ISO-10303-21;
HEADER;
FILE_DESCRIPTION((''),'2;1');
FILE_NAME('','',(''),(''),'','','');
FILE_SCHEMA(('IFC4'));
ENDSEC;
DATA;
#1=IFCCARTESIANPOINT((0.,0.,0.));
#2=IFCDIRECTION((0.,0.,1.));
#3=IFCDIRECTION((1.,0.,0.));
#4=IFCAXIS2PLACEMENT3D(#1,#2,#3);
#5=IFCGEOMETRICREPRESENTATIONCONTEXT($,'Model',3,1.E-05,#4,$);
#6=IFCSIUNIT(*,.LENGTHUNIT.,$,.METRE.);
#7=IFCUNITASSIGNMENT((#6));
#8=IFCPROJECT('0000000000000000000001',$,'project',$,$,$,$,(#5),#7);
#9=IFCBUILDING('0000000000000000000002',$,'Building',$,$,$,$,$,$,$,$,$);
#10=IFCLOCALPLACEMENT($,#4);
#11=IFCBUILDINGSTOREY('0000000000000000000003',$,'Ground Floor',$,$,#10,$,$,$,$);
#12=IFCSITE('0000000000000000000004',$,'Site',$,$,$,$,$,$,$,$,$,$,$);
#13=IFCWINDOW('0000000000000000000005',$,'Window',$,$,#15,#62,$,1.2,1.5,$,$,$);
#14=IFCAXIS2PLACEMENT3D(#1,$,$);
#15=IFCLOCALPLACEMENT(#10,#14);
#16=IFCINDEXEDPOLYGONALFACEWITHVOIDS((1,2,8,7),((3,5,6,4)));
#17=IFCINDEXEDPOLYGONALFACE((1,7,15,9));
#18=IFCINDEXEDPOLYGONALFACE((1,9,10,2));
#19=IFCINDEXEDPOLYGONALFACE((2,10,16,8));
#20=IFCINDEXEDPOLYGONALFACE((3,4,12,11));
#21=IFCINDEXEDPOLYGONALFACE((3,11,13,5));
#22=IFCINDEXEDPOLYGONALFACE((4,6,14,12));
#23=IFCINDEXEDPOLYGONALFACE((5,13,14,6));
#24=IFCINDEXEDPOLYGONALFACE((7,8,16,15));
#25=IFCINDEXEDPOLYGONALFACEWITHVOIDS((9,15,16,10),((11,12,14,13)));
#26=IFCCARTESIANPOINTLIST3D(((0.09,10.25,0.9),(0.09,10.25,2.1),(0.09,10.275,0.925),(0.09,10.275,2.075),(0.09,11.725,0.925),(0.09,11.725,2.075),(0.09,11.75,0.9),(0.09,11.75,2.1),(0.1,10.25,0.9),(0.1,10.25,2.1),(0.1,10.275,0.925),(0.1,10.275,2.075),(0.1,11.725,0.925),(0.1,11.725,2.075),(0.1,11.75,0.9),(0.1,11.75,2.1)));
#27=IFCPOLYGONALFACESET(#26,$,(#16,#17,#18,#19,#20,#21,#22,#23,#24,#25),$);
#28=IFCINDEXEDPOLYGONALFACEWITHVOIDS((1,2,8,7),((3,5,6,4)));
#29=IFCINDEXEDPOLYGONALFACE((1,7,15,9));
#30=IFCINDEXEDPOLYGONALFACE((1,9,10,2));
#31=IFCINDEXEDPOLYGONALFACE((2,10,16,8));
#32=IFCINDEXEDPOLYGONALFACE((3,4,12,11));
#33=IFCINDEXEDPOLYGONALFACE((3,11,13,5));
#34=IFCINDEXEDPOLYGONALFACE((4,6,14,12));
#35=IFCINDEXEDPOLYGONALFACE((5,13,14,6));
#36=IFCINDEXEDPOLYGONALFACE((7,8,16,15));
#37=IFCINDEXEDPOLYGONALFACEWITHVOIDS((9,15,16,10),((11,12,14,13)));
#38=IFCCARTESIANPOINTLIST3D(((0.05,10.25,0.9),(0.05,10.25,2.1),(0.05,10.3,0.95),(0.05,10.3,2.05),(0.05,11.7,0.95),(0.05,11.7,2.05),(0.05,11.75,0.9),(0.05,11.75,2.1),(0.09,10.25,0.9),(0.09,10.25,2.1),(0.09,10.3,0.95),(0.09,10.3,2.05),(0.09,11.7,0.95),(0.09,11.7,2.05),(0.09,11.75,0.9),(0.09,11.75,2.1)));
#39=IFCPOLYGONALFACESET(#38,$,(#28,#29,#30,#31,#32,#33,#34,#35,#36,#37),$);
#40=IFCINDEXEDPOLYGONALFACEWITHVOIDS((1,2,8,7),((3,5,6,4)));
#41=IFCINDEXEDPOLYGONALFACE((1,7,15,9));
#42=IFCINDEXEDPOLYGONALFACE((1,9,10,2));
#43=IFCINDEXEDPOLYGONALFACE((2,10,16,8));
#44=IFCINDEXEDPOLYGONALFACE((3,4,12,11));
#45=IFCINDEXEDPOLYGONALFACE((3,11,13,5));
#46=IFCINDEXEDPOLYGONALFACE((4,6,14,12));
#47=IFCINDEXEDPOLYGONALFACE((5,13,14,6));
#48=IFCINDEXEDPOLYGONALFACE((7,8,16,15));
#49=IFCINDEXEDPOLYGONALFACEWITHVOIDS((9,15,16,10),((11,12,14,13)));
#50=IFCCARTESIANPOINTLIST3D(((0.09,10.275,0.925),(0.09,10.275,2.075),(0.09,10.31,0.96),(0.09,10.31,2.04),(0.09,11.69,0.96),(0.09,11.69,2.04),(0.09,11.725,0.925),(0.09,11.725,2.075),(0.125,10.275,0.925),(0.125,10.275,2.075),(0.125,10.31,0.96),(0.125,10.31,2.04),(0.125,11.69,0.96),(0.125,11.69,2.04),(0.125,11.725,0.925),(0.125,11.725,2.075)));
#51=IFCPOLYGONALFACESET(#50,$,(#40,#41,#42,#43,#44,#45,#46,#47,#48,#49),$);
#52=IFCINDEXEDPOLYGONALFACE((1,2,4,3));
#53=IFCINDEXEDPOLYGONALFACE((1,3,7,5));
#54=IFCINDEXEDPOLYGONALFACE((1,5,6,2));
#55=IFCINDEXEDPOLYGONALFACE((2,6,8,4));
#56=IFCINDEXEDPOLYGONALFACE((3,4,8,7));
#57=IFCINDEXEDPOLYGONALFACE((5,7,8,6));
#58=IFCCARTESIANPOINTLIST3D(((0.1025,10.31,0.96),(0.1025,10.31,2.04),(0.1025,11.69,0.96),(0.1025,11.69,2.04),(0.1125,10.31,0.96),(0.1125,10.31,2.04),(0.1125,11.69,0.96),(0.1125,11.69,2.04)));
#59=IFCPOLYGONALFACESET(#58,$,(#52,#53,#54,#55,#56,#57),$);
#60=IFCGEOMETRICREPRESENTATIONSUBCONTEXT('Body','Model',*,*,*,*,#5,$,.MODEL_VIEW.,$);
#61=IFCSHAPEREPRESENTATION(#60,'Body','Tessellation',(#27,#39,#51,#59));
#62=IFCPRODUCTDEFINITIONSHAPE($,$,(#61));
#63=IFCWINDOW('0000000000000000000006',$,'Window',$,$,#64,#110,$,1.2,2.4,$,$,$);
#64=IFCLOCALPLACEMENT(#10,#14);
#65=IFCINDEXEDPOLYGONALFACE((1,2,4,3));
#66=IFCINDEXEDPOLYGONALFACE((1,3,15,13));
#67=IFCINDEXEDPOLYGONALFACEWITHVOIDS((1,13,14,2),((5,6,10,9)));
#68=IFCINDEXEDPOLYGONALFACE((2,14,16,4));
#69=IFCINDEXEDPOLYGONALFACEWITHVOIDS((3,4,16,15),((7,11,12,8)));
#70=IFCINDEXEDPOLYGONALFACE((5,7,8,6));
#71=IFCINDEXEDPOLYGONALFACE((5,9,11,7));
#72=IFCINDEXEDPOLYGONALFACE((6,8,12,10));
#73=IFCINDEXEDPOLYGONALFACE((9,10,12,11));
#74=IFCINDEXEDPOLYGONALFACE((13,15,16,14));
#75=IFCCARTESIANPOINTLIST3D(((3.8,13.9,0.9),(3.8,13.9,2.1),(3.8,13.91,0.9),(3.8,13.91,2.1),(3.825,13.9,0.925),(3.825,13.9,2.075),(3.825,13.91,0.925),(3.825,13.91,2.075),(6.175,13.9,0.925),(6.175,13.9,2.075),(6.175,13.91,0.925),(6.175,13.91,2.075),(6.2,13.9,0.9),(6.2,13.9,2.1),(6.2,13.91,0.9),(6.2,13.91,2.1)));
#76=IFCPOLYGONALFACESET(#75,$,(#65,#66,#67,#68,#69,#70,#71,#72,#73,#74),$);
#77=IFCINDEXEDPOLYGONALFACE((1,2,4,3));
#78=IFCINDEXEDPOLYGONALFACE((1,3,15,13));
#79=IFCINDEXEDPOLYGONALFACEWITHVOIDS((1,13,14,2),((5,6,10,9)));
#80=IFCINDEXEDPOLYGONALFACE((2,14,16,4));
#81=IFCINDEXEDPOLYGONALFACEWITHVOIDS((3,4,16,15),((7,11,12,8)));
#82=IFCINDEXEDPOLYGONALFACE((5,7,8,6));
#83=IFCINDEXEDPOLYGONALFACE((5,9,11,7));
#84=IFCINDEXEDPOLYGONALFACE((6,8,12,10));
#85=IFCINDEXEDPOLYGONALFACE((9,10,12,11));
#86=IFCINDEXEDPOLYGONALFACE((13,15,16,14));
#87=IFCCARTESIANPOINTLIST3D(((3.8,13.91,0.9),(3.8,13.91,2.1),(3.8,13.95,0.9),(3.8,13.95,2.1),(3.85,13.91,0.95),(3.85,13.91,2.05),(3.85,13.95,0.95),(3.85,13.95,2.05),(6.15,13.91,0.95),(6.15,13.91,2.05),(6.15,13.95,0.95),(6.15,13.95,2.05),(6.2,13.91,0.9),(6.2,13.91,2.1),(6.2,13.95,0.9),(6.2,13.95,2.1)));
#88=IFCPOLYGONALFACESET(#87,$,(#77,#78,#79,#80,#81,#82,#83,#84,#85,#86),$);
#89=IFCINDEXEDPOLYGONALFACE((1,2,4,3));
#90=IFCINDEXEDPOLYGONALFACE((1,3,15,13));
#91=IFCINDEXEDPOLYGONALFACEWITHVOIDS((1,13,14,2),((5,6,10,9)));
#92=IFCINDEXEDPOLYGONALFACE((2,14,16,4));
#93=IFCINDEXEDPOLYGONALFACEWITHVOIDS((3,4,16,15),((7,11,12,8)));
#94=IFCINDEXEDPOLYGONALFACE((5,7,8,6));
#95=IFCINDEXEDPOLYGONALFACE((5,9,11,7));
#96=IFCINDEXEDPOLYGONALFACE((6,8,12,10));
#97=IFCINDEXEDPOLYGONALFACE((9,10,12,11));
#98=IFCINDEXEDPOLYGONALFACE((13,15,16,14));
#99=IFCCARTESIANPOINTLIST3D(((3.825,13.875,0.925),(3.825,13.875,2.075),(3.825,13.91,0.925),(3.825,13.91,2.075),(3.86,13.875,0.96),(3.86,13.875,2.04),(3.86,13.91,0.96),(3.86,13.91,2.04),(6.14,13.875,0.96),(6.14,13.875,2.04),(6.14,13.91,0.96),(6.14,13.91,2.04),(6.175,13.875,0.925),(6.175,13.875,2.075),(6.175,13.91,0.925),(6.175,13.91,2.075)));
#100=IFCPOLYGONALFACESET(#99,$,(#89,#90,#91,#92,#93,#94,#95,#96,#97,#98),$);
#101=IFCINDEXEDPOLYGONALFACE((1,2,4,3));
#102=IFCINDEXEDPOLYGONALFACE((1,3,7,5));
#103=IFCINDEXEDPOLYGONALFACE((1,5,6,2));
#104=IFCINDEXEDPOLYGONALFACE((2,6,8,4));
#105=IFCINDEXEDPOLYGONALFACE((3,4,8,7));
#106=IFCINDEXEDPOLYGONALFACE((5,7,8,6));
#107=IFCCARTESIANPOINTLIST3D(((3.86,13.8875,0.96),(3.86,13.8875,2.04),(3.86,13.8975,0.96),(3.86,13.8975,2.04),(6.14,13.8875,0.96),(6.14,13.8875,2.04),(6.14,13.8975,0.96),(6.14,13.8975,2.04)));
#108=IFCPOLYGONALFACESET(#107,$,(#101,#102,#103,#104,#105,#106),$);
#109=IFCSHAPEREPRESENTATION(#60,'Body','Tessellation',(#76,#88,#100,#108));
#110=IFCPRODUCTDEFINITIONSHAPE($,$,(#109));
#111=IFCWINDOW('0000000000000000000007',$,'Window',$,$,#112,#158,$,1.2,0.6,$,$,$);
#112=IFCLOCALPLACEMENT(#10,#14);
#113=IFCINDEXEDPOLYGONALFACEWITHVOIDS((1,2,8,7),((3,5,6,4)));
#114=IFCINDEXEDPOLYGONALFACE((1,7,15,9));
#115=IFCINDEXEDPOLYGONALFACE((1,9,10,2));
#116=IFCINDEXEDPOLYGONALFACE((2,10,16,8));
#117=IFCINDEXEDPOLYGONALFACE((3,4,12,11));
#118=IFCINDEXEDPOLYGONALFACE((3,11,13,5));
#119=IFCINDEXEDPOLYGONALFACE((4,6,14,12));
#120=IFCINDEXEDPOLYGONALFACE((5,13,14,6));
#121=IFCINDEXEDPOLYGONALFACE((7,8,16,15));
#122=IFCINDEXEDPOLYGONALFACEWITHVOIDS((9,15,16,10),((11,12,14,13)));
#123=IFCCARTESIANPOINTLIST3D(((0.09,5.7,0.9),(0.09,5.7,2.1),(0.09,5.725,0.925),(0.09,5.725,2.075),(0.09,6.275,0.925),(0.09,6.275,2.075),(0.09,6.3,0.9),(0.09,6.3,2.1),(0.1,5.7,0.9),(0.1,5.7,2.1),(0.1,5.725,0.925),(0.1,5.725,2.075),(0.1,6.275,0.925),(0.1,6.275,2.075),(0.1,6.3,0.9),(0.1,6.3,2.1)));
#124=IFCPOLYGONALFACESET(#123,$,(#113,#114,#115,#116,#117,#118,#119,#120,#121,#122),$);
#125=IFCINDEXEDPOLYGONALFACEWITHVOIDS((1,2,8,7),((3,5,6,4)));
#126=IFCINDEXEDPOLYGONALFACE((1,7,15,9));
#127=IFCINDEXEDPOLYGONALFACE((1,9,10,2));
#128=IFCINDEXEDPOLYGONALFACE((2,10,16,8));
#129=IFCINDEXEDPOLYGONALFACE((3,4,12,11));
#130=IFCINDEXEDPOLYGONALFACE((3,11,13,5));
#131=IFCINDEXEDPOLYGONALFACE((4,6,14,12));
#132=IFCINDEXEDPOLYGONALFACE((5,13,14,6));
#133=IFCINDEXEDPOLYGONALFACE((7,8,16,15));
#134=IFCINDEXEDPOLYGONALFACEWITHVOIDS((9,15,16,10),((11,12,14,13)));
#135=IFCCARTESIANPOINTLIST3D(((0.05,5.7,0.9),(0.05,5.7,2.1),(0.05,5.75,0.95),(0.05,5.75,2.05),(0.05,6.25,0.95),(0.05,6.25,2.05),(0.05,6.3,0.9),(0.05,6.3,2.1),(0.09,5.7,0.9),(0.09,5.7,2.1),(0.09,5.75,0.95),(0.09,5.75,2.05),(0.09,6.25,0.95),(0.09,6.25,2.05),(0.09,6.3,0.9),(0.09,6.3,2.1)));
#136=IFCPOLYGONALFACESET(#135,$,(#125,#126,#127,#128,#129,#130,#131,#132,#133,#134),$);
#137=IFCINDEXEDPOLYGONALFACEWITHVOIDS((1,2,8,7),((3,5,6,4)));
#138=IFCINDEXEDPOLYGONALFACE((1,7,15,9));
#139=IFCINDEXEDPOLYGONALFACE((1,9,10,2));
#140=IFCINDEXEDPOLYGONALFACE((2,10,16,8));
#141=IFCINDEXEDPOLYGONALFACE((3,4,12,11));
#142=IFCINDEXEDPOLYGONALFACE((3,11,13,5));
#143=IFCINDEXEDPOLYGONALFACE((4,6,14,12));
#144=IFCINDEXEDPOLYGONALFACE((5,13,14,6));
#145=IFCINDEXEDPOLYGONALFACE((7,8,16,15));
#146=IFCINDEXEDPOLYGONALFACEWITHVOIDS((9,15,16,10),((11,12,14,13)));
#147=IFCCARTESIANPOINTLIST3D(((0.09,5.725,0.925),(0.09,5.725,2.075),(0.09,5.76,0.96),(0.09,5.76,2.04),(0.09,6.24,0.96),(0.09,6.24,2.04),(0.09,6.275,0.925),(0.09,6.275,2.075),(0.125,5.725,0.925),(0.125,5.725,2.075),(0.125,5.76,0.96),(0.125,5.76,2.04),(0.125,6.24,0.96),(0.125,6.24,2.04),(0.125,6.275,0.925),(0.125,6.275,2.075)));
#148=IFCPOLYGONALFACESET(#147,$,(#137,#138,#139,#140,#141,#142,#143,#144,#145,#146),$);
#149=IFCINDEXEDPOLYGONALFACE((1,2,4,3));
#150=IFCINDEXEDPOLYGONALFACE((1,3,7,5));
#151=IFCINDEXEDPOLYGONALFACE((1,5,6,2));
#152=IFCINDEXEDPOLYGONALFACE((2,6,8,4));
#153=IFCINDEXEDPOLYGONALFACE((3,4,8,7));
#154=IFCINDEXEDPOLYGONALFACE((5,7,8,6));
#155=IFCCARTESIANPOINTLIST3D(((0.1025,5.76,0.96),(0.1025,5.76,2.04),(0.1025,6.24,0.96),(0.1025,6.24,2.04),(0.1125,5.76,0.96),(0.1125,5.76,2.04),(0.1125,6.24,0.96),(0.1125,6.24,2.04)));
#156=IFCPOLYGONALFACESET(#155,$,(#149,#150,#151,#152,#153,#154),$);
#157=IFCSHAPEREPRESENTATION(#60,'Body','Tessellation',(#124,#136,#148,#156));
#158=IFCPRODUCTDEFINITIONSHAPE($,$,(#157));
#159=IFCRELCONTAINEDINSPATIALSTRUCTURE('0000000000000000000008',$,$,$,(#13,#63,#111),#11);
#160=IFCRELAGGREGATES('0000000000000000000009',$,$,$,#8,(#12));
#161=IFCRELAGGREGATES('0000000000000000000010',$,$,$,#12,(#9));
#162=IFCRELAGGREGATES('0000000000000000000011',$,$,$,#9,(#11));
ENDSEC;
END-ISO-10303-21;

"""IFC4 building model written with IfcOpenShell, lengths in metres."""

from ifc_helpers import new_model, si_unit, frame, origin_with_axes, place, context, subcontext, project, spatial, line, indexed_curve, outline, extrude, element, save


model = new_model("IFC4")

# Units and contexts
model_context = context("Model", 3, precision=1e-05, world=origin_with_axes())
body_context = subcontext(model_context, "Body", "Model", "MODEL_VIEW")
ifc_project = project(units=[si_unit("LENGTHUNIT", "METRE")], contexts=[model_context])

# Site, building, storey
site = spatial("IfcSite", under=ifc_project, Name="Site")
building = spatial("IfcBuilding", under=site, Name="Building")
storey_placement = place(None, origin_with_axes())
storey = spatial("IfcBuildingStorey", under=building, at=storey_placement, Name="Ground Floor")

# Windows
for number, where, z_axis, x_axis, name in (
    (1, (0.0, 11.75, 0.9), (0.0, 0.0, 1.0), (0.0, -1.0, 0.0), "Window"),
):
    element("IfcWindow", number, at=place(storey_placement, frame(where, z_axis=z_axis, x_axis=x_axis)), inside=storey, Name=name, OverallHeight=1.2, OverallWidth=1.5, context=body_context, shape_type="SweptSolid", body=[
        extrude(outline(indexed_curve([(0.0, 0.0), (1.5, 0.0), (1.5, 1.2), (0.0, 1.2)], segments=[line(1, 2, 3, 4, 1)]), holes=[indexed_curve([(0.025, 0.025), (1.475, 0.025), (1.475, 1.175), (0.025, 1.175)], segments=[line(1, 2, 3, 4, 1)])]), frame((0.0, 0.09, 0.0), z_axis=(0.0, -1.0, 0.0), x_axis=(1.0, 0.0, 0.0)), (0.0, 0.0, -1.0), 0.01),
        extrude(outline(indexed_curve([(0.0, 0.0), (1.5, 0.0), (1.5, 1.2), (0.0, 1.2)], segments=[line(1, 2, 3, 4, 1)]), holes=[indexed_curve([(0.05, 0.05), (1.45, 0.05), (1.45, 1.15), (0.05, 1.15)], segments=[line(1, 2, 3, 4, 1)])]), frame((0.0, 0.05, 0.0), z_axis=(0.0, -1.0, 0.0), x_axis=(1.0, 0.0, 0.0)), (0.0, 0.0, -1.0), 0.04),
        extrude(outline(indexed_curve([(0.0, 0.0), (1.45, 0.0), (1.45, 1.15), (0.0, 1.15)], segments=[line(1, 2, 3, 4, 1)]), holes=[indexed_curve([(0.035, 0.035), (1.415, 0.035), (1.415, 1.115), (0.035, 1.115)], segments=[line(1, 2, 3, 4, 1)])]), frame((0.025, 0.09, 0.025), z_axis=(0.0, -1.0, 0.0), x_axis=(1.0, 0.0, 0.0)), (0.0, 0.0, -1.0), 0.035),
        extrude(outline(indexed_curve([(0.035, 0.035), (1.415, 0.035), (1.415, 1.115), (0.035, 1.115)], segments=[line(1, 2, 3, 4, 1)])), frame((0.025, 0.1025, 0.025), z_axis=(0.0, -1.0, 0.0), x_axis=(1.0, 0.0, 0.0)), (0.0, 0.0, -1.0), 0.01),
    ])
window_1_placement = place(storey_placement, frame((6.2, 14.0, 0.9), z_axis=(0.0, 0.0, 1.0), x_axis=(-1.0, 0.0, 0.0)))
element("IfcWindow", 2, at=window_1_placement, inside=storey, Name="Window", OverallHeight=1.2, OverallWidth=2.4, context=body_context, shape_type="SweptSolid", body=[
    extrude(outline(indexed_curve([(0.0, 0.0), (2.4, 0.0), (2.4, 1.2), (0.0, 1.2)], segments=[line(1, 2, 3, 4, 1)]), holes=[indexed_curve([(0.025, 0.025), (2.375, 0.025), (2.375, 1.175), (0.025, 1.175)], segments=[line(1, 2, 3, 4, 1)])]), frame((0.0, 0.09, 0.0), z_axis=(0.0, -1.0, 0.0), x_axis=(1.0, 0.0, 0.0)), (0.0, 0.0, -1.0), 0.01),
    extrude(outline(indexed_curve([(0.0, 0.0), (2.4, 0.0), (2.4, 1.2), (0.0, 1.2)], segments=[line(1, 2, 3, 4, 1)]), holes=[indexed_curve([(0.05, 0.05), (2.35, 0.05), (2.35, 1.15), (0.05, 1.15)], segments=[line(1, 2, 3, 4, 1)])]), frame((0.0, 0.05, 0.0), z_axis=(0.0, -1.0, 0.0), x_axis=(1.0, 0.0, 0.0)), (0.0, 0.0, -1.0), 0.04),
    extrude(outline(indexed_curve([(0.0, 0.0), (2.35, 0.0), (2.35, 1.15), (0.0, 1.15)], segments=[line(1, 2, 3, 4, 1)]), holes=[indexed_curve([(0.035, 0.035), (2.315, 0.035), (2.315, 1.115), (0.035, 1.115)], segments=[line(1, 2, 3, 4, 1)])]), frame((0.025, 0.09, 0.025), z_axis=(0.0, -1.0, 0.0), x_axis=(1.0, 0.0, 0.0)), (0.0, 0.0, -1.0), 0.035),
    extrude(outline(indexed_curve([(0.035, 0.035), (2.315, 0.035), (2.315, 1.115), (0.035, 1.115)], segments=[line(1, 2, 3, 4, 1)])), frame((0.025, 0.1025, 0.025), z_axis=(0.0, -1.0, 0.0), x_axis=(1.0, 0.0, 0.0)), (0.0, 0.0, -1.0), 0.01),
])
window_2_placement = place(storey_placement, frame((0.0, 6.3, 0.9), z_axis=(0.0, 0.0, 1.0), x_axis=(0.0, -1.0, 0.0)))
element("IfcWindow", 3, at=window_2_placement, inside=storey, Name="Window", OverallHeight=1.2, OverallWidth=0.6, context=body_context, shape_type="SweptSolid", body=[
    extrude(outline(indexed_curve([(0.0, 0.0), (0.6, 0.0), (0.6, 1.2), (0.0, 1.2)], segments=[line(1, 2, 3, 4, 1)]), holes=[indexed_curve([(0.025, 0.025), (0.575, 0.025), (0.575, 1.175), (0.025, 1.175)], segments=[line(1, 2, 3, 4, 1)])]), frame((0.0, 0.09, 0.0), z_axis=(0.0, -1.0, 0.0), x_axis=(1.0, 0.0, 0.0)), (0.0, 0.0, -1.0), 0.01),
    extrude(outline(indexed_curve([(0.0, 0.0), (0.6, 0.0), (0.6, 1.2), (0.0, 1.2)], segments=[line(1, 2, 3, 4, 1)]), holes=[indexed_curve([(0.05, 0.05), (0.55, 0.05), (0.55, 1.15), (0.05, 1.15)], segments=[line(1, 2, 3, 4, 1)])]), frame((0.0, 0.05, 0.0), z_axis=(0.0, -1.0, 0.0), x_axis=(1.0, 0.0, 0.0)), (0.0, 0.0, -1.0), 0.04),
    extrude(outline(indexed_curve([(0.0, 0.0), (0.55, 0.0), (0.55, 1.15), (0.0, 1.15)], segments=[line(1, 2, 3, 4, 1)]), holes=[indexed_curve([(0.035, 0.035), (0.515, 0.035), (0.515, 1.115), (0.035, 1.115)], segments=[line(1, 2, 3, 4, 1)])]), frame((0.025, 0.09, 0.025), z_axis=(0.0, -1.0, 0.0), x_axis=(1.0, 0.0, 0.0)), (0.0, 0.0, -1.0), 0.035),
    extrude(outline(indexed_curve([(0.035, 0.035), (0.515, 0.035), (0.515, 1.115), (0.035, 1.115)], segments=[line(1, 2, 3, 4, 1)])), frame((0.025, 0.1025, 0.025), z_axis=(0.0, -1.0, 0.0), x_axis=(1.0, 0.0, 0.0)), (0.0, 0.0, -1.0), 0.01),
])

save(model, "model.ifc")
